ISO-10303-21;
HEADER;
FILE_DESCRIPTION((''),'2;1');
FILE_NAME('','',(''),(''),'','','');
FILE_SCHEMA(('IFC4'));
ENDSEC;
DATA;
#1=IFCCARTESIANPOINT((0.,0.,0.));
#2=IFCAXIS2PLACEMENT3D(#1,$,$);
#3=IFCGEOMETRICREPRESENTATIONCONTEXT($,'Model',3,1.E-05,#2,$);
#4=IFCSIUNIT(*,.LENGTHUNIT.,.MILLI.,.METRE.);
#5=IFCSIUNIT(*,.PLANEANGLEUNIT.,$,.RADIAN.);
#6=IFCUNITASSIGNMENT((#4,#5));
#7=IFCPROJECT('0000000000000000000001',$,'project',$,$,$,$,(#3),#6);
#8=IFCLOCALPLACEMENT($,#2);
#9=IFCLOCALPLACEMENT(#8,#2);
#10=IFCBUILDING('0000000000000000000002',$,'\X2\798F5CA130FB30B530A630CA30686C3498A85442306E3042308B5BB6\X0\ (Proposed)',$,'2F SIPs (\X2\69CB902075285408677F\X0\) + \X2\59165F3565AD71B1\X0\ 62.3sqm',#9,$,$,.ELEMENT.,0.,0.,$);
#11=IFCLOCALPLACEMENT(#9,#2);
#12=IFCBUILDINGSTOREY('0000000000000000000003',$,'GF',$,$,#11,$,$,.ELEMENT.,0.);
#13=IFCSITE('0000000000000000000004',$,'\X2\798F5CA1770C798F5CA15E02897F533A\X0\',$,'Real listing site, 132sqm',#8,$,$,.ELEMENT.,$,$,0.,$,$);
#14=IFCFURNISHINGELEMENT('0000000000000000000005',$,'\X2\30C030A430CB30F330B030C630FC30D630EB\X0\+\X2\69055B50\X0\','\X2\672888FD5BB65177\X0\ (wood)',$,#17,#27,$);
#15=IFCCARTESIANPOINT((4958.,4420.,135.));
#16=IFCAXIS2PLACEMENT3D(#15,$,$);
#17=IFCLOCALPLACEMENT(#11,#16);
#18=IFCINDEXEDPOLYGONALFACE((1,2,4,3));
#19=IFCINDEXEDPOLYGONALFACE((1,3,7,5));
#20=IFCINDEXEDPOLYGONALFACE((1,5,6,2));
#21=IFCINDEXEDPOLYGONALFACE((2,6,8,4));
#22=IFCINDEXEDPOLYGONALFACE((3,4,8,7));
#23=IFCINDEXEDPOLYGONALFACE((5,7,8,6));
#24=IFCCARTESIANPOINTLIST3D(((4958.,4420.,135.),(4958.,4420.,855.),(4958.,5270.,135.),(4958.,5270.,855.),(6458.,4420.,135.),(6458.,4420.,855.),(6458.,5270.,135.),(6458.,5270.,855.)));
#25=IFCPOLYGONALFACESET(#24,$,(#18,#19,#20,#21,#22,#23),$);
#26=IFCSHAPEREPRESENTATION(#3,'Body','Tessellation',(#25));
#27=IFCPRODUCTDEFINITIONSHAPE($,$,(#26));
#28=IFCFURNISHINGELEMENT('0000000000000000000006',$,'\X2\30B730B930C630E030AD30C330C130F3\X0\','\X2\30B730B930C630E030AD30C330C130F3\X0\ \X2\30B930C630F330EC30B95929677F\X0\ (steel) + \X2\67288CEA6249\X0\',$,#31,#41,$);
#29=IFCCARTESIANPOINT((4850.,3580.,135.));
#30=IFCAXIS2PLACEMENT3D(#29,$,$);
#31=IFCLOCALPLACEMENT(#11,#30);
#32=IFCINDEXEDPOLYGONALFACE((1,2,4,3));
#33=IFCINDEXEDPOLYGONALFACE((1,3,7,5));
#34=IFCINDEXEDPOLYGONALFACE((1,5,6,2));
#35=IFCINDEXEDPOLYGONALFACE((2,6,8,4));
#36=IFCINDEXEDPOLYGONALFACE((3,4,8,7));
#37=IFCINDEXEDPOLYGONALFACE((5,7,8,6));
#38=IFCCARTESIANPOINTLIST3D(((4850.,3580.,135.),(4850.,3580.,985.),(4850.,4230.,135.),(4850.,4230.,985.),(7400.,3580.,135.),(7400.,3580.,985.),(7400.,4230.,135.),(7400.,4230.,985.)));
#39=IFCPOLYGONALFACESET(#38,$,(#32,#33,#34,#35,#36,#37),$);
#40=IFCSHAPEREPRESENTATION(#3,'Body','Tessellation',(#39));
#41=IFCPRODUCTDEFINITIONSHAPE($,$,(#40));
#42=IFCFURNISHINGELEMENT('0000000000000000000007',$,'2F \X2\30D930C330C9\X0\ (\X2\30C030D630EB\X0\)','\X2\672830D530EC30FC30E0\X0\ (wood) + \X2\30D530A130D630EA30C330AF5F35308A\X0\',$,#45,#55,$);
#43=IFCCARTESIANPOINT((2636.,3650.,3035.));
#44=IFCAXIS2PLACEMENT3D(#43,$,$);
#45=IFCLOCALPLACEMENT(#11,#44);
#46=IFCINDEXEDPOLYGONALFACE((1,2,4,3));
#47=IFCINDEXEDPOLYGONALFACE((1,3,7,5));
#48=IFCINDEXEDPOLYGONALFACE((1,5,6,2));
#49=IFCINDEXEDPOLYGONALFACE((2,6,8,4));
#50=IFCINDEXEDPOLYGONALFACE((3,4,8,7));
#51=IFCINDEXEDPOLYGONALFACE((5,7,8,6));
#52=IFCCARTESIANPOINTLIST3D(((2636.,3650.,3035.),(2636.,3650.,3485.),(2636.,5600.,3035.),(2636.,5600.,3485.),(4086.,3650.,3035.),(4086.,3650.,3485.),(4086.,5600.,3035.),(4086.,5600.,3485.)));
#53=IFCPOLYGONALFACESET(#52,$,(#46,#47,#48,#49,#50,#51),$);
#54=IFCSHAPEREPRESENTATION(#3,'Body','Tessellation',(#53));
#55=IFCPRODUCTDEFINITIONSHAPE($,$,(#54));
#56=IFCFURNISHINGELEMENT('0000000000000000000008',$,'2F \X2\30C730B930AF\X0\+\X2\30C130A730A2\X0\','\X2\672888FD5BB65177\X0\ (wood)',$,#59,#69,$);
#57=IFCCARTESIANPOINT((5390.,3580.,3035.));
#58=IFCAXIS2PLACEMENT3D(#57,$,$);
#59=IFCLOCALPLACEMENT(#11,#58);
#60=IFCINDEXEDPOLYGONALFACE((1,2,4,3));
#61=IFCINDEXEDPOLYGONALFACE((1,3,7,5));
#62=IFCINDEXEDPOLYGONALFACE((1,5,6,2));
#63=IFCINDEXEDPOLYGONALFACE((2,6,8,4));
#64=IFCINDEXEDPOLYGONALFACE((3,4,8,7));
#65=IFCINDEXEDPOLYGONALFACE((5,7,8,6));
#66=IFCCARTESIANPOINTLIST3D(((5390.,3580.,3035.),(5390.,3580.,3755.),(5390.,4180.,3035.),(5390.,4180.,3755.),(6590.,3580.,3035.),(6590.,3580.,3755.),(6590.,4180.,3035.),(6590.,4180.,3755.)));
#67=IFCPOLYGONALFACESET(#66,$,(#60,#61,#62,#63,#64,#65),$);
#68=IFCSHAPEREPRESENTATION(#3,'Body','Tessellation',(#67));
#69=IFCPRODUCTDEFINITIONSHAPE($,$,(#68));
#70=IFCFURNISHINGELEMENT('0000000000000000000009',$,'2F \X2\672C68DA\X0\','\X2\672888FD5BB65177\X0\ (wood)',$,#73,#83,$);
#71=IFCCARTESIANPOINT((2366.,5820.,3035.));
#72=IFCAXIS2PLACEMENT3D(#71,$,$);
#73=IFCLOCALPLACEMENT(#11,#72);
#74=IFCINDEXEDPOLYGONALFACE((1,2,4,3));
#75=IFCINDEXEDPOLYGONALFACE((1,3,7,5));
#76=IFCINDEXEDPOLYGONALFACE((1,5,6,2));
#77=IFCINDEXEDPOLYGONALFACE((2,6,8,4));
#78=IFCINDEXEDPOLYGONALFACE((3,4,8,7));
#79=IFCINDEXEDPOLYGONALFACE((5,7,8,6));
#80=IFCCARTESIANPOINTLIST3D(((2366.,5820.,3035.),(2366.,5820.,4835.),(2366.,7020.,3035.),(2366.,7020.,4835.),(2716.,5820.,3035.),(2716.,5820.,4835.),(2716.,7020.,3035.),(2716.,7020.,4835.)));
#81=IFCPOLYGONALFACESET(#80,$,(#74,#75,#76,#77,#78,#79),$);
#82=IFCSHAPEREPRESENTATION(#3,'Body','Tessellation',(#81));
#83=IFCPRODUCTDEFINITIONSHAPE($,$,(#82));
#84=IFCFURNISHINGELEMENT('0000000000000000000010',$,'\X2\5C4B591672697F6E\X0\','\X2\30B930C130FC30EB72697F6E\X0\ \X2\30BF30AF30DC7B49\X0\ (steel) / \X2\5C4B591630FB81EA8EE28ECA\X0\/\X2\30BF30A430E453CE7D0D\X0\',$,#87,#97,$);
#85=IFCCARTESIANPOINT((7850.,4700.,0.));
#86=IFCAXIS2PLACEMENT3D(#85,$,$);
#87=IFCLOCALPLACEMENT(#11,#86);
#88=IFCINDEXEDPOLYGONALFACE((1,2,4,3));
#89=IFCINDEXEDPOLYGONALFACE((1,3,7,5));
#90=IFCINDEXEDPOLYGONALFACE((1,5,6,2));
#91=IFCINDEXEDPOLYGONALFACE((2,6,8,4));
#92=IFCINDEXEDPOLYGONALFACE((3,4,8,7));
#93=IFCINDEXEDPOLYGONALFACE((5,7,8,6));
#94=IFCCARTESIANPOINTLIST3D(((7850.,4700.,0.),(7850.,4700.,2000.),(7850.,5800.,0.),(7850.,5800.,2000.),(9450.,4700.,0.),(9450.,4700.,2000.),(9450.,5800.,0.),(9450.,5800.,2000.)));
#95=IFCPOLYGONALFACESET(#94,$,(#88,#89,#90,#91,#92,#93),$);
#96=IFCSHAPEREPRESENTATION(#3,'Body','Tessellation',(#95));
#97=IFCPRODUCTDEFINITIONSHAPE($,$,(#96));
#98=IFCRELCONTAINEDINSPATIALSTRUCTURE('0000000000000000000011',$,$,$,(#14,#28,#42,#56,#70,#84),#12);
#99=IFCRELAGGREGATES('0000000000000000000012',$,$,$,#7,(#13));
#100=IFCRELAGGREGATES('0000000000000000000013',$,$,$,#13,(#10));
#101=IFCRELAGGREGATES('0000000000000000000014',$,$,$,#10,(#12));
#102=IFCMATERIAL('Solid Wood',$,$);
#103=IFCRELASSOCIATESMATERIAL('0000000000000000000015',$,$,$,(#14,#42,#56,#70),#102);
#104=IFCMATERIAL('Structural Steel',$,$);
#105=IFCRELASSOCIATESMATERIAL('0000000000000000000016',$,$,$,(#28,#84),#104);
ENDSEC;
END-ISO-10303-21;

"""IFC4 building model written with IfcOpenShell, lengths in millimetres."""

from ifc_helpers import new_model, si_unit, frame, frame_2d, origin, place, context, project, spatial, rectangle, extrude, material, element, save


model = new_model("IFC4")

# Units and contexts
model_context = context("Model", 3, precision=1e-05, world=origin())
ifc_project = project(units=[si_unit("LENGTHUNIT", "METRE", prefix="MILLI"), si_unit("PLANEANGLEUNIT", "RADIAN")], contexts=[model_context])

# Site, building, storey
site_placement = place(None, origin())
site = spatial("IfcSite", under=ifc_project, at=site_placement, Name="福岡県福岡市西区", ObjectType="Real listing site, 132sqm", CompositionType="ELEMENT", RefElevation=0.0)
building_placement = place(site_placement, origin())
building = spatial("IfcBuilding", under=site, at=building_placement, Name="福岡・サウナと水風呂のある家 (Proposed)", ObjectType="2F SIPs (構造用合板) + 外張断熱 62.3sqm", CompositionType="ELEMENT", ElevationOfRefHeight=0.0, ElevationOfTerrain=0.0)
storey_placement = place(building_placement, origin())
storey = spatial("IfcBuildingStorey", under=building, at=storey_placement, Name="GF", CompositionType="ELEMENT", Elevation=0.0)

# Shared definitions
ifc_material_1 = material(Name="Solid Wood")

# Shared definitions
ifc_material_2 = material(Name="Structural Steel")

# Furnishing elements
furnishing_1_placement = place(storey_placement, frame((4958.0, 4420.0, 135.0)))
element("IfcFurnishingElement", 1, at=furnishing_1_placement, inside=storey, material=ifc_material_1, Name="ダイニングテーブル+椅子", Description="木製家具 (wood)", context=model_context, shape_type="SweptSolid", body=[
    extrude(rectangle(XDim=1500.0, YDim=850.0, at=frame_2d((750.0, 425.0))), frame((4958.0, 4420.0, 135.0)), (0.0, 0.0, 1.0), 720.0),
])
furnishing_2_placement = place(storey_placement, frame((4850.0, 3580.0, 135.0)))
element("IfcFurnishingElement", 2, at=furnishing_2_placement, inside=storey, material=ifc_material_2, Name="システムキッチン", Description="システムキッチン ステンレス天板 (steel) + 木質扉", context=model_context, shape_type="SweptSolid", body=[
    extrude(rectangle(XDim=2550.0, YDim=650.0, at=frame_2d((1275.0, 325.0))), frame((4850.0, 3580.0, 135.0)), (0.0, 0.0, 1.0), 850.0),
])
furnishing_3_placement = place(storey_placement, frame((2636.0, 3650.0, 3035.0)))
element("IfcFurnishingElement", 3, at=furnishing_3_placement, inside=storey, material=ifc_material_1, Name="2F ベッド (ダブル)", Description="木フレーム (wood) + ファブリック張り", context=model_context, shape_type="SweptSolid", body=[
    extrude(rectangle(XDim=1450.0, YDim=1950.0, at=frame_2d((725.0, 975.0))), frame((2636.0, 3650.0, 3035.0)), (0.0, 0.0, 1.0), 450.0),
])
furnishing_4_placement = place(storey_placement, frame((5390.0, 3580.0, 3035.0)))
element("IfcFurnishingElement", 4, at=furnishing_4_placement, inside=storey, material=ifc_material_1, Name="2F デスク+チェア", Description="木製家具 (wood)", context=model_context, shape_type="SweptSolid", body=[
    extrude(rectangle(XDim=1200.0, YDim=600.0, at=frame_2d((600.0, 300.0))), frame((5390.0, 3580.0, 3035.0)), (0.0, 0.0, 1.0), 720.0),
])
furnishing_5_placement = place(storey_placement, frame((2366.0, 5820.0, 3035.0)))
element("IfcFurnishingElement", 5, at=furnishing_5_placement, inside=storey, material=ifc_material_1, Name="2F 本棚", Description="木製家具 (wood)", context=model_context, shape_type="SweptSolid", body=[
    extrude(rectangle(XDim=350.0, YDim=1200.0, at=frame_2d((175.0, 600.0))), frame((2366.0, 5820.0, 3035.0)), (0.0, 0.0, 1.0), 1800.0),
])
furnishing_6_placement = place(storey_placement, frame((7850.0, 4700.0, 0.0)))
element("IfcFurnishingElement", 6, at=furnishing_6_placement, inside=storey, material=ifc_material_2, Name="屋外物置", Description="スチール物置 タクボ等 (steel) / 屋外・自転車/タイヤ収納", context=model_context, shape_type="SweptSolid", body=[
    extrude(rectangle(XDim=1600.0, YDim=1100.0, at=frame_2d((800.0, 550.0))), frame((7850.0, 4700.0, 0.0)), (0.0, 0.0, 1.0), 2000.0),
])

save(model, "model.ifc")
